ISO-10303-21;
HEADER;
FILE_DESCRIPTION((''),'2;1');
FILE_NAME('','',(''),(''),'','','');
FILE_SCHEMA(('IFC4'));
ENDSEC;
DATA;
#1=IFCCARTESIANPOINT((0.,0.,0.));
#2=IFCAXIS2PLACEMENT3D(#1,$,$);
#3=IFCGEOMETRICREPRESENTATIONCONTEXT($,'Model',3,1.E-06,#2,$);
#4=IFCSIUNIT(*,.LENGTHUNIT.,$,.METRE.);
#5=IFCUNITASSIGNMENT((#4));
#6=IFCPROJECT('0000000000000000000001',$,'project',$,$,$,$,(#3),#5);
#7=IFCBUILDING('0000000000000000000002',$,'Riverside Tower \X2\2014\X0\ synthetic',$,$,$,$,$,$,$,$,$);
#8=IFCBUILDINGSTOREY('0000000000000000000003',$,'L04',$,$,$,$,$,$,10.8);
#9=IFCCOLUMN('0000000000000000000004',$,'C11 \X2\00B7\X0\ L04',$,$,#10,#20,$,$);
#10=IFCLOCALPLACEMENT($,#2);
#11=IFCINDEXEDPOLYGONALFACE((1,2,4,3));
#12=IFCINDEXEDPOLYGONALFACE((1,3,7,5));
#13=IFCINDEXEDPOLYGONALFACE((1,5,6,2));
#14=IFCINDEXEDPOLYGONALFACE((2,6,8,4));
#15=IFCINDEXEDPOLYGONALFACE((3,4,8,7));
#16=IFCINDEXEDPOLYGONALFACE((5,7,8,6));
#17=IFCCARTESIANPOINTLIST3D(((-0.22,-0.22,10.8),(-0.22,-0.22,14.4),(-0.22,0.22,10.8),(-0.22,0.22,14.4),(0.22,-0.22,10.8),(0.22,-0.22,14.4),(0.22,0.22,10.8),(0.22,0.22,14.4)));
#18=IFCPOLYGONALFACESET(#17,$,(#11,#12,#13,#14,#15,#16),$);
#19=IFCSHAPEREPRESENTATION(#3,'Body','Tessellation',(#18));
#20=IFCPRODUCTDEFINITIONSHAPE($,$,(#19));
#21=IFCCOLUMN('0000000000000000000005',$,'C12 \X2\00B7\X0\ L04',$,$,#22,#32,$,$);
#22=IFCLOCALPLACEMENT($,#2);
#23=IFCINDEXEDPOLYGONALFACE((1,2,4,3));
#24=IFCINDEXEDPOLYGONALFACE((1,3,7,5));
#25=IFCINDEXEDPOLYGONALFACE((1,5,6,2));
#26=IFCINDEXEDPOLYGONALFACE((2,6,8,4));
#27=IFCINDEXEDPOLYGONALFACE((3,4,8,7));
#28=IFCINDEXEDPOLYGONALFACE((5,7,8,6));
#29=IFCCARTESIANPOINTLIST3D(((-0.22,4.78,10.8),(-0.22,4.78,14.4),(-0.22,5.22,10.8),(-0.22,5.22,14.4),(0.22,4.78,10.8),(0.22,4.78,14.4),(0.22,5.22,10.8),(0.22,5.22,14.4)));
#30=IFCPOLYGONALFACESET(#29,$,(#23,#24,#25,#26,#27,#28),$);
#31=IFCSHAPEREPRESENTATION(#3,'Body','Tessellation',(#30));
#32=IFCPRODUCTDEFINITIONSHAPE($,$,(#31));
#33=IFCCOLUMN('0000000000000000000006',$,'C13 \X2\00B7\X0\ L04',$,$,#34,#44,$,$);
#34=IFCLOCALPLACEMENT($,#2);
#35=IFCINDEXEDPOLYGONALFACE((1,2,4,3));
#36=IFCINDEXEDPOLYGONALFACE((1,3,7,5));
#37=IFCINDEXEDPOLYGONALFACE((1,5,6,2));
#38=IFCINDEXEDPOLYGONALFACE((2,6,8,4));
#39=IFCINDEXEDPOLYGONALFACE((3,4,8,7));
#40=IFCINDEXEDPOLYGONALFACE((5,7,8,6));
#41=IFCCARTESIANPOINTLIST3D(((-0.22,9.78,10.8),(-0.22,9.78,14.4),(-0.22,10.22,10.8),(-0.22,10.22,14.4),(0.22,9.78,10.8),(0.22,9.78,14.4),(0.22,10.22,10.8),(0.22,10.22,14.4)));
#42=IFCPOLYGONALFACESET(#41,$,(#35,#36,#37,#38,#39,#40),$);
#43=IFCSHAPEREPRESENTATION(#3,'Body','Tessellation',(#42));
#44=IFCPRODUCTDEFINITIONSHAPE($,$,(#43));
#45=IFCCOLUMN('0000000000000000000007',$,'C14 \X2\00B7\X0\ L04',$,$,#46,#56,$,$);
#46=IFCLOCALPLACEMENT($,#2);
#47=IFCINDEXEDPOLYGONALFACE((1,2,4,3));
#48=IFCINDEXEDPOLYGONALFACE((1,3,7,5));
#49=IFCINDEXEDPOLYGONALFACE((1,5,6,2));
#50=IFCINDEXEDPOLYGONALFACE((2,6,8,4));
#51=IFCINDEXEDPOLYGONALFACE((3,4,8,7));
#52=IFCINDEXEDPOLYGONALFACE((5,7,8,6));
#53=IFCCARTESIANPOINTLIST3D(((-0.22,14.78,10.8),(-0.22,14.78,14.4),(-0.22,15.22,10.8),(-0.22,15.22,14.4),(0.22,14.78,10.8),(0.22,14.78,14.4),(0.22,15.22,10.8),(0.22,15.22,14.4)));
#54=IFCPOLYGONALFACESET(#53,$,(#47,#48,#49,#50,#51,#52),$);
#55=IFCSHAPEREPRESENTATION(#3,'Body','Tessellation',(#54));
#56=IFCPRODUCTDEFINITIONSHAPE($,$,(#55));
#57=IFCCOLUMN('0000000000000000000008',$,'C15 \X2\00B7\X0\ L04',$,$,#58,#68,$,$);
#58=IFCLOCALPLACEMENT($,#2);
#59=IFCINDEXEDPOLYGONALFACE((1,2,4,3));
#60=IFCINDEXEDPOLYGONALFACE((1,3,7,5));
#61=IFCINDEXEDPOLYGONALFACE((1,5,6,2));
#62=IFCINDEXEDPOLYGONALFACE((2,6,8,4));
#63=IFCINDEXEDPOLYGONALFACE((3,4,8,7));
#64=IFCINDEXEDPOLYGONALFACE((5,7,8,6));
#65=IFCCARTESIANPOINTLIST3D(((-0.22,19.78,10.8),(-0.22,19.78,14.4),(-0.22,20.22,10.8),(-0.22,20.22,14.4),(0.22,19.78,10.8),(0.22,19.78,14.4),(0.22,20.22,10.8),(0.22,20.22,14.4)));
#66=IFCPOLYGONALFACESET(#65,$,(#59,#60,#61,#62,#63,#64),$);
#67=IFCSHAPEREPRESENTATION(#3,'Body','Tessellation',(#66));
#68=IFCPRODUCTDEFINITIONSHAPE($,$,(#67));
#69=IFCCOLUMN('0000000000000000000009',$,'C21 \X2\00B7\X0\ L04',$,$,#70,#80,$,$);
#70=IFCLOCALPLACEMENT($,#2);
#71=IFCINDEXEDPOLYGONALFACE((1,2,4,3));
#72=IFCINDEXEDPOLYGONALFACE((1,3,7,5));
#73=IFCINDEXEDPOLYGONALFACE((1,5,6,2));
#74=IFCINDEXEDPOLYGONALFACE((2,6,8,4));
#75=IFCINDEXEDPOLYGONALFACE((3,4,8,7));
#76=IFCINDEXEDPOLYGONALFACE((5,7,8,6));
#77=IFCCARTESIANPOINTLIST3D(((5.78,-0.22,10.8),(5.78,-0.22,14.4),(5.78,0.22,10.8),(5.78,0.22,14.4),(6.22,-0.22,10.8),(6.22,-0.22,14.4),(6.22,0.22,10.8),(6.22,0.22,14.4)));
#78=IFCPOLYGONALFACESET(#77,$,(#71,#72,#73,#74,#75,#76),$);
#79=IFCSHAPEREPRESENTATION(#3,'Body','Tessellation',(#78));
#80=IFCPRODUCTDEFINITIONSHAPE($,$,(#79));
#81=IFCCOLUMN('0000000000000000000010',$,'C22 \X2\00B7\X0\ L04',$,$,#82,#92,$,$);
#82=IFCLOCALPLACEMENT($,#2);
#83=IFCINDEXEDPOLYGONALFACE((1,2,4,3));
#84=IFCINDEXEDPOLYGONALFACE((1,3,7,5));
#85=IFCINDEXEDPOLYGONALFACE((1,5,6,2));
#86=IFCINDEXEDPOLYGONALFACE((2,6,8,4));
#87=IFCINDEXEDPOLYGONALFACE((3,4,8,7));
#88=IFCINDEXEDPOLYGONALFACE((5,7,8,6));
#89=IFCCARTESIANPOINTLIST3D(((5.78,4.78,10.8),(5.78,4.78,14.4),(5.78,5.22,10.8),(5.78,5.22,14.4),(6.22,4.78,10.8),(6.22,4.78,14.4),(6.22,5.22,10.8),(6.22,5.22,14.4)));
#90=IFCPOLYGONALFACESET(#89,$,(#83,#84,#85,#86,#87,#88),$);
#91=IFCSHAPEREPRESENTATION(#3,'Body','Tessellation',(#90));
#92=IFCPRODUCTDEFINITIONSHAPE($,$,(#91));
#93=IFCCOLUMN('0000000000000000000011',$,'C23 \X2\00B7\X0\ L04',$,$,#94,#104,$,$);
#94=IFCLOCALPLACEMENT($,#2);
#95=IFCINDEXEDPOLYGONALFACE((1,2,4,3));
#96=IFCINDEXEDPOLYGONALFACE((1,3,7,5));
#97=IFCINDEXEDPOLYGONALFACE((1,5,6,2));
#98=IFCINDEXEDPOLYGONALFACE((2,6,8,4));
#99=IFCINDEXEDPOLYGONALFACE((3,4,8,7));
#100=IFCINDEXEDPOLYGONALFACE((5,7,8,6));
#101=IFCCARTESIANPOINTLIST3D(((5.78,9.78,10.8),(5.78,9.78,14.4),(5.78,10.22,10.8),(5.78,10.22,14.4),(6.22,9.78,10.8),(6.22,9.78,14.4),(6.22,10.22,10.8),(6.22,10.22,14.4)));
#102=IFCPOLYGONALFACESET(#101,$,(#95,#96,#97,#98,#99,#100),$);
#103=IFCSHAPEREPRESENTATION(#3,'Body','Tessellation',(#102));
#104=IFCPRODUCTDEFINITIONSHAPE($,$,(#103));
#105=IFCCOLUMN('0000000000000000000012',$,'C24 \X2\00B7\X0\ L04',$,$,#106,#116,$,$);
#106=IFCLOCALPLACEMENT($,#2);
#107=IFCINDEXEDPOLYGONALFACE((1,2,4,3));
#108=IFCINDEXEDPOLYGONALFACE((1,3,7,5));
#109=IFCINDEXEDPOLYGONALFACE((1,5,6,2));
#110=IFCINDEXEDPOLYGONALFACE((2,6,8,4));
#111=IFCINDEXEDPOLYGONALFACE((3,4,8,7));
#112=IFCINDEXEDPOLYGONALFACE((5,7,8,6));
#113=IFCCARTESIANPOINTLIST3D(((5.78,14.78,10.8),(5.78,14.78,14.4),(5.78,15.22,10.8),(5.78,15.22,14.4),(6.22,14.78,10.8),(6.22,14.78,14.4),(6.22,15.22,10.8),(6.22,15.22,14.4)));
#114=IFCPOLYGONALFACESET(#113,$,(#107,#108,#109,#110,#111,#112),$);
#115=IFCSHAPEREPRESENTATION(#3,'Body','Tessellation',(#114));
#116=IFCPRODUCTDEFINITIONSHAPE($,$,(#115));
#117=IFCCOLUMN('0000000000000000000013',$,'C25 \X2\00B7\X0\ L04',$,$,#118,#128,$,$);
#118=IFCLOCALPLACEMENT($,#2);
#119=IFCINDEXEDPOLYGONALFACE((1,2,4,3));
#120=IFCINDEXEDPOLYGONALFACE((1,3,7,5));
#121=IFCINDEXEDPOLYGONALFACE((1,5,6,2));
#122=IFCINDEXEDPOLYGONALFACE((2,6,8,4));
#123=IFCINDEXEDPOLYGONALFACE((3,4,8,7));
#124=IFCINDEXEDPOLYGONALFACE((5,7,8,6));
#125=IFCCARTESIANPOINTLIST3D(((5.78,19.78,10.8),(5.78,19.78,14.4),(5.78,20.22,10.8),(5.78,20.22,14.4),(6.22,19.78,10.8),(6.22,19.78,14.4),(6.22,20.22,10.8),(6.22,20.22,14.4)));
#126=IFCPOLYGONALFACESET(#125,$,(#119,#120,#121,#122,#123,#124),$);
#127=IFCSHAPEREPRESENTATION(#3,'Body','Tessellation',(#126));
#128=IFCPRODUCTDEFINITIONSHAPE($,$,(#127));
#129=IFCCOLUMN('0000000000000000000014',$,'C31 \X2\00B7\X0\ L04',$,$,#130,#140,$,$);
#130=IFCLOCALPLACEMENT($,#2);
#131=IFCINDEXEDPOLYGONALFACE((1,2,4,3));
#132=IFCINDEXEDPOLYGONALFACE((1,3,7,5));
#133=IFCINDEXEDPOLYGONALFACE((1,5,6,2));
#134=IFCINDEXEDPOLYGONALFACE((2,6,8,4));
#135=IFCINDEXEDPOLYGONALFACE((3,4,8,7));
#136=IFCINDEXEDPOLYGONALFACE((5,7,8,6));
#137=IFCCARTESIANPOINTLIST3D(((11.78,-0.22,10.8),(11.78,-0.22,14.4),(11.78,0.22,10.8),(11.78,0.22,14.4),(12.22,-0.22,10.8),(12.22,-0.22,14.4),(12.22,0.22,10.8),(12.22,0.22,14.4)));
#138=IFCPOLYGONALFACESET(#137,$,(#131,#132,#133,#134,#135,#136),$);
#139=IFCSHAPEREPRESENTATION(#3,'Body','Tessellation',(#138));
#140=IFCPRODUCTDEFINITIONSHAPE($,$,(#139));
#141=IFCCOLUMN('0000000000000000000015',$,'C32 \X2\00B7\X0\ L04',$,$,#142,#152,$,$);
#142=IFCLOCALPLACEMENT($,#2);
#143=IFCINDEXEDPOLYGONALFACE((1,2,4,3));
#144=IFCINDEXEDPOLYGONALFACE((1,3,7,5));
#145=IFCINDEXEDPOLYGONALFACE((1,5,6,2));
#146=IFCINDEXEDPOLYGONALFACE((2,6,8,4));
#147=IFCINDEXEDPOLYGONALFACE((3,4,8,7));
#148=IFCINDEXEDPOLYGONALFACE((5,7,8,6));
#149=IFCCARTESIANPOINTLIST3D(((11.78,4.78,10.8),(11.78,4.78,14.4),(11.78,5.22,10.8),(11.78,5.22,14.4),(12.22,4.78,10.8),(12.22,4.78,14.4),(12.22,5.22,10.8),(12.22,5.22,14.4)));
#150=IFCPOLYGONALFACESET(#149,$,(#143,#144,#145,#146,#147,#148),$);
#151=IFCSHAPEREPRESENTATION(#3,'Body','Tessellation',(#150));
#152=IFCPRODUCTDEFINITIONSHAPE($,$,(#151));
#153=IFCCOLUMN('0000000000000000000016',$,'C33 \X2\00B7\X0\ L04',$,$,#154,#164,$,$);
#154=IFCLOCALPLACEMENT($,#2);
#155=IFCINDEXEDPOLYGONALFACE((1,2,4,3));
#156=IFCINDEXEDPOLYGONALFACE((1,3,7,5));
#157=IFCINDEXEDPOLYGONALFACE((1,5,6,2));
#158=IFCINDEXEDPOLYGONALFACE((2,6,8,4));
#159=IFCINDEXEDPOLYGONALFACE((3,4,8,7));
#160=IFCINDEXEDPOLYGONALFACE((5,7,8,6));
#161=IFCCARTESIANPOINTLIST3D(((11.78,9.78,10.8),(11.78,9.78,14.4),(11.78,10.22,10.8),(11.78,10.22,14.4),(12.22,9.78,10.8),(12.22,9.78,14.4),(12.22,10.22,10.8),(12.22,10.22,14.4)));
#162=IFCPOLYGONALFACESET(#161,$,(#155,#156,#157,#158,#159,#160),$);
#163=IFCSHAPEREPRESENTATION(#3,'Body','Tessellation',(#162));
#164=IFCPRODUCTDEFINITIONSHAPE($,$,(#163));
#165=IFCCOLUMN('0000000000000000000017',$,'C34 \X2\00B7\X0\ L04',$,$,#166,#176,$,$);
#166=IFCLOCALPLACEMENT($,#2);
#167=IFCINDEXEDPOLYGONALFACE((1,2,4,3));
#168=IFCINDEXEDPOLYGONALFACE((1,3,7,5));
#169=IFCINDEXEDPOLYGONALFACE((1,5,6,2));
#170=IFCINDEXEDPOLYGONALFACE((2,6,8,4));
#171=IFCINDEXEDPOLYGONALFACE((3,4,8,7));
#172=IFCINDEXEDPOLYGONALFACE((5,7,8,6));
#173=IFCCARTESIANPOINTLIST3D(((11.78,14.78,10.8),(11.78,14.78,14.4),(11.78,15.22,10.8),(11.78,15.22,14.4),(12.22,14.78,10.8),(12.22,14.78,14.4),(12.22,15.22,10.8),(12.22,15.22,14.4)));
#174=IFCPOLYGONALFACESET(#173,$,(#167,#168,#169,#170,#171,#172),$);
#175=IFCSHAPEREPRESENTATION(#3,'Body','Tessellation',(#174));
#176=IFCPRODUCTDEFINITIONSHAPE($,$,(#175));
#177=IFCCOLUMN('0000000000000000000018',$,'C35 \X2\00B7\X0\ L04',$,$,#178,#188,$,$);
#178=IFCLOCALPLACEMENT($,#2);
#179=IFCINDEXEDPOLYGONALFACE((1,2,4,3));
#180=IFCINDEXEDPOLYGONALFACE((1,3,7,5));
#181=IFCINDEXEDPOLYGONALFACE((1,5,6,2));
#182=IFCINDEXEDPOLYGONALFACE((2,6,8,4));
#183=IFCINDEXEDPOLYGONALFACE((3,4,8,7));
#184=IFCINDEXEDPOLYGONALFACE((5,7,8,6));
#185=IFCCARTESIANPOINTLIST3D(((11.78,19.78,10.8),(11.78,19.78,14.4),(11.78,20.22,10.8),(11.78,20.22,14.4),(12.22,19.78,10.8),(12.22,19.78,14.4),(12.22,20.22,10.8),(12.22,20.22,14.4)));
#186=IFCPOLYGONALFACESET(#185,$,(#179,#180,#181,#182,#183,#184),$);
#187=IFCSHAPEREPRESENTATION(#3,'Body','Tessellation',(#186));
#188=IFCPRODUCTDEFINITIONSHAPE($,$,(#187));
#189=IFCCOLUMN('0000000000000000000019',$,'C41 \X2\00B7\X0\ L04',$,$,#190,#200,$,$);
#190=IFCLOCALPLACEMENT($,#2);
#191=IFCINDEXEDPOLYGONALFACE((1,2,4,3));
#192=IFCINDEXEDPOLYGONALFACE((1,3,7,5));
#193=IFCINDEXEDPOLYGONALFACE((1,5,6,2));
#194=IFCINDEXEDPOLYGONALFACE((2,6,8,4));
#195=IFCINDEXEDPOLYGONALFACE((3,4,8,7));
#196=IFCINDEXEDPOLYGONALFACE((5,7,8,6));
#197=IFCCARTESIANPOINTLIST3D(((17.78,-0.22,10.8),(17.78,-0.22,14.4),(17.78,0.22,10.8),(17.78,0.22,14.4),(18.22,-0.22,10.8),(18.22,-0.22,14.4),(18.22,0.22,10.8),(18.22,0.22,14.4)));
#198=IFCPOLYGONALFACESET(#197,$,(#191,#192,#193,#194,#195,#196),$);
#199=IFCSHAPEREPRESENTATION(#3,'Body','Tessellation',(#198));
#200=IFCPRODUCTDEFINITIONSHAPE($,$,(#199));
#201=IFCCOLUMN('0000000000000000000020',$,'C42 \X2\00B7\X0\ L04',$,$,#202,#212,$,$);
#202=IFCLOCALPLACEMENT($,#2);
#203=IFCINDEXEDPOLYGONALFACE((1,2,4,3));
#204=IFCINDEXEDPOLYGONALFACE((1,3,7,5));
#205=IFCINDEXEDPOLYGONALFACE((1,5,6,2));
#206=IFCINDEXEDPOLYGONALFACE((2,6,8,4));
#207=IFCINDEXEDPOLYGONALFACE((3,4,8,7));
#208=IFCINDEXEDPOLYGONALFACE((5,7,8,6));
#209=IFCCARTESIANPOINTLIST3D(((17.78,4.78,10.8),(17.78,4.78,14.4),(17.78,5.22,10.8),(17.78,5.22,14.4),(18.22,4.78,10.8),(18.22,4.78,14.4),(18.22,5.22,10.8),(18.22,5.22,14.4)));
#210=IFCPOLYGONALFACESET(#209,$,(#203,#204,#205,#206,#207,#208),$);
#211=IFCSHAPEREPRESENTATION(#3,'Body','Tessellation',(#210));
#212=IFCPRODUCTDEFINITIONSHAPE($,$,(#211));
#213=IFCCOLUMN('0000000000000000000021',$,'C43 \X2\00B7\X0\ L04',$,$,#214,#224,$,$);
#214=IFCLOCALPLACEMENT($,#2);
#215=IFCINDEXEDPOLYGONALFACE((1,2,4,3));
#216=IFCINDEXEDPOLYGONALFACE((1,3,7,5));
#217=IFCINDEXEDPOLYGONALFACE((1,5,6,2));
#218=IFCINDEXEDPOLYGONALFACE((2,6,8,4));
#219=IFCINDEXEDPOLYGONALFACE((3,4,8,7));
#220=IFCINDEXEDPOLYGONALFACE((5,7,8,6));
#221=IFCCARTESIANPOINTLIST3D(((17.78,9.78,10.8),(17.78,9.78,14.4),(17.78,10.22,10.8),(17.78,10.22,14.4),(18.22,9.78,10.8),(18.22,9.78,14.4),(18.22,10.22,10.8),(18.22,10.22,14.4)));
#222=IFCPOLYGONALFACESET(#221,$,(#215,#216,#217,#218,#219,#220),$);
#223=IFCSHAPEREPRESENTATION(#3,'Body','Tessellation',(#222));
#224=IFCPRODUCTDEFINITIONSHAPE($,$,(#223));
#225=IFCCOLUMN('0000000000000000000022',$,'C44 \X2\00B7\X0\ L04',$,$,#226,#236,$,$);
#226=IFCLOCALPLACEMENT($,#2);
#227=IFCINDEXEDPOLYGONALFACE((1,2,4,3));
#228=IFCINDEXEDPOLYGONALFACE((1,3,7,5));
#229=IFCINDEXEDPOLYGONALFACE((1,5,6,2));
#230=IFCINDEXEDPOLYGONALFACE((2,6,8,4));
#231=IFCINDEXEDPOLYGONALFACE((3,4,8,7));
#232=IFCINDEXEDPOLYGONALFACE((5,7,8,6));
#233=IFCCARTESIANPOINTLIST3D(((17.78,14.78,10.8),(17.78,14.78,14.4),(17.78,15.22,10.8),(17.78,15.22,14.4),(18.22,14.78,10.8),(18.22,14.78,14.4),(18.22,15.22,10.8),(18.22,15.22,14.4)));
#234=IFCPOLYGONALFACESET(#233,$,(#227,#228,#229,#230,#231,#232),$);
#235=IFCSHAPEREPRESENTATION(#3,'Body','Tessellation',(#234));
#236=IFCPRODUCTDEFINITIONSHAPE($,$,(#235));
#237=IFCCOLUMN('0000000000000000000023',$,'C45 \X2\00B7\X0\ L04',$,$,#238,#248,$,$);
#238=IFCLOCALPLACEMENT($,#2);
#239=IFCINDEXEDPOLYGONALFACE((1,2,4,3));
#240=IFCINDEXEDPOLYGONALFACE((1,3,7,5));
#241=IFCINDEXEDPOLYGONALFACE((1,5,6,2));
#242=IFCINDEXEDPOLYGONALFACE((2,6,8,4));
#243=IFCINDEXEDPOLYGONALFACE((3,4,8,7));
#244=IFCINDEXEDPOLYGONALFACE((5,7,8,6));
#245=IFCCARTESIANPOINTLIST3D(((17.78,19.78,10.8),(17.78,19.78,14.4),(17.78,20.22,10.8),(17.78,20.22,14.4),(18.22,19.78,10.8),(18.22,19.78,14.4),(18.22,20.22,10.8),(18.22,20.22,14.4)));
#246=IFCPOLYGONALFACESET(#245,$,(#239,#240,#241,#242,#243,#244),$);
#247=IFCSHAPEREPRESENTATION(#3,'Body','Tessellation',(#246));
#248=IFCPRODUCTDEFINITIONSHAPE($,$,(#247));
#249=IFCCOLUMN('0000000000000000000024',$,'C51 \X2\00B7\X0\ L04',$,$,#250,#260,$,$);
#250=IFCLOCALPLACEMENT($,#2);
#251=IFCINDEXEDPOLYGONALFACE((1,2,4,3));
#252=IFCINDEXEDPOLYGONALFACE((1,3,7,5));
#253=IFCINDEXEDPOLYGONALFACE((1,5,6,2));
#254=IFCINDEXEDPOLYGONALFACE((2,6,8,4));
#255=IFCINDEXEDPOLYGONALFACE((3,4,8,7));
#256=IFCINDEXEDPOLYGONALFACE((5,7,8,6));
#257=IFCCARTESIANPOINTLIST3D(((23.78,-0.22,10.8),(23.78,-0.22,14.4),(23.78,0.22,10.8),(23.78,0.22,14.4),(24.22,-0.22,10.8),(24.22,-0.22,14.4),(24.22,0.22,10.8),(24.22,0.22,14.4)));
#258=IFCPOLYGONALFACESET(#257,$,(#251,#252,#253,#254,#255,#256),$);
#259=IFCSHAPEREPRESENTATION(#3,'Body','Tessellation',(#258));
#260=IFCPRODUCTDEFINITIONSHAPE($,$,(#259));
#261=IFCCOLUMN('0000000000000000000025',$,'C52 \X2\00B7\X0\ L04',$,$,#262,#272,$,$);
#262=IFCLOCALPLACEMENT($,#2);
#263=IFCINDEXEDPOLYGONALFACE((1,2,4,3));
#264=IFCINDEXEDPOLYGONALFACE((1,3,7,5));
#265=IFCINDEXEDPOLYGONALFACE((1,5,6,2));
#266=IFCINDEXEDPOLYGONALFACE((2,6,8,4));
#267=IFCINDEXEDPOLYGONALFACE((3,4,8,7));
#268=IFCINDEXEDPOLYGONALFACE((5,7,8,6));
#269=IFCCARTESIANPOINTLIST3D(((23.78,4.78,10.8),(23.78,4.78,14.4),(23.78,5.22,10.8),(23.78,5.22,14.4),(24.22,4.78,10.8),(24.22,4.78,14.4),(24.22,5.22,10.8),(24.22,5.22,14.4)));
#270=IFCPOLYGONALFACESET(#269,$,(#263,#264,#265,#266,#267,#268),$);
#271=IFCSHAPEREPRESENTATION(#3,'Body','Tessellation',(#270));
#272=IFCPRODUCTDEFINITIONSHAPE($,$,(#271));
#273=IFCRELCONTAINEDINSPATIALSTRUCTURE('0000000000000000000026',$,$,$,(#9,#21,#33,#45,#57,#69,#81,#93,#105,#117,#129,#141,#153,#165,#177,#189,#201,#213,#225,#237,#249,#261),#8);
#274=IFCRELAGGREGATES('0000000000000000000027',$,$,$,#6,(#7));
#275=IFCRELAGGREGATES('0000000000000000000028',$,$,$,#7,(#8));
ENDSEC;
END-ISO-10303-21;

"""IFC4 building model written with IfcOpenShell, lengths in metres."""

from ifc_helpers import new_model, si_unit, frame, origin, place, context, project, spatial, rectangle, extrude, element, save


model = new_model("IFC4")

# Units and contexts
model_context = context("Model", 3, precision=1e-06, world=origin())
ifc_project = project(units=[si_unit("LENGTHUNIT", "METRE")], contexts=[model_context])

# Building, storey
building = spatial("IfcBuilding", under=ifc_project, Name="Riverside Tower — synthetic")
storey = spatial("IfcBuildingStorey", under=building, Name="L04", Elevation=10.8)

# Columns
for number, where, name in (
    (1, (0.0, 0.0, 10.8), "C11 · L04"),
    (2, (0.0, 5.0, 10.8), "C12 · L04"),
    (3, (0.0, 10.0, 10.8), "C13 · L04"),
    (4, (0.0, 15.0, 10.8), "C14 · L04"),
    (5, (0.0, 20.0, 10.8), "C15 · L04"),
    (6, (6.0, 0.0, 10.8), "C21 · L04"),
    (7, (6.0, 5.0, 10.8), "C22 · L04"),
    (8, (6.0, 10.0, 10.8), "C23 · L04"),
    (9, (6.0, 15.0, 10.8), "C24 · L04"),
    (10, (6.0, 20.0, 10.8), "C25 · L04"),
    (11, (12.0, 0.0, 10.8), "C31 · L04"),
    (12, (12.0, 5.0, 10.8), "C32 · L04"),
    (13, (12.0, 10.0, 10.8), "C33 · L04"),
    (14, (12.0, 15.0, 10.8), "C34 · L04"),
    (15, (12.0, 20.0, 10.8), "C35 · L04"),
    (16, (18.0, 0.0, 10.8), "C41 · L04"),
    (17, (18.0, 5.0, 10.8), "C42 · L04"),
    (18, (18.0, 10.0, 10.8), "C43 · L04"),
    (19, (18.0, 15.0, 10.8), "C44 · L04"),
    (20, (18.0, 20.0, 10.8), "C45 · L04"),
    (21, (24.0, 0.0, 10.8), "C51 · L04"),
    (22, (24.0, 5.0, 10.8), "C52 · L04"),
):
    element("IfcColumn", number, at=place(None, frame(where)), inside=storey, Name=name, context=model_context, shape_type="SweptSolid", body=[
        extrude(rectangle(XDim=0.44, YDim=0.44), origin(), (0.0, 0.0, 1.0), 3.6),
    ])

save(model, "model.ifc")
